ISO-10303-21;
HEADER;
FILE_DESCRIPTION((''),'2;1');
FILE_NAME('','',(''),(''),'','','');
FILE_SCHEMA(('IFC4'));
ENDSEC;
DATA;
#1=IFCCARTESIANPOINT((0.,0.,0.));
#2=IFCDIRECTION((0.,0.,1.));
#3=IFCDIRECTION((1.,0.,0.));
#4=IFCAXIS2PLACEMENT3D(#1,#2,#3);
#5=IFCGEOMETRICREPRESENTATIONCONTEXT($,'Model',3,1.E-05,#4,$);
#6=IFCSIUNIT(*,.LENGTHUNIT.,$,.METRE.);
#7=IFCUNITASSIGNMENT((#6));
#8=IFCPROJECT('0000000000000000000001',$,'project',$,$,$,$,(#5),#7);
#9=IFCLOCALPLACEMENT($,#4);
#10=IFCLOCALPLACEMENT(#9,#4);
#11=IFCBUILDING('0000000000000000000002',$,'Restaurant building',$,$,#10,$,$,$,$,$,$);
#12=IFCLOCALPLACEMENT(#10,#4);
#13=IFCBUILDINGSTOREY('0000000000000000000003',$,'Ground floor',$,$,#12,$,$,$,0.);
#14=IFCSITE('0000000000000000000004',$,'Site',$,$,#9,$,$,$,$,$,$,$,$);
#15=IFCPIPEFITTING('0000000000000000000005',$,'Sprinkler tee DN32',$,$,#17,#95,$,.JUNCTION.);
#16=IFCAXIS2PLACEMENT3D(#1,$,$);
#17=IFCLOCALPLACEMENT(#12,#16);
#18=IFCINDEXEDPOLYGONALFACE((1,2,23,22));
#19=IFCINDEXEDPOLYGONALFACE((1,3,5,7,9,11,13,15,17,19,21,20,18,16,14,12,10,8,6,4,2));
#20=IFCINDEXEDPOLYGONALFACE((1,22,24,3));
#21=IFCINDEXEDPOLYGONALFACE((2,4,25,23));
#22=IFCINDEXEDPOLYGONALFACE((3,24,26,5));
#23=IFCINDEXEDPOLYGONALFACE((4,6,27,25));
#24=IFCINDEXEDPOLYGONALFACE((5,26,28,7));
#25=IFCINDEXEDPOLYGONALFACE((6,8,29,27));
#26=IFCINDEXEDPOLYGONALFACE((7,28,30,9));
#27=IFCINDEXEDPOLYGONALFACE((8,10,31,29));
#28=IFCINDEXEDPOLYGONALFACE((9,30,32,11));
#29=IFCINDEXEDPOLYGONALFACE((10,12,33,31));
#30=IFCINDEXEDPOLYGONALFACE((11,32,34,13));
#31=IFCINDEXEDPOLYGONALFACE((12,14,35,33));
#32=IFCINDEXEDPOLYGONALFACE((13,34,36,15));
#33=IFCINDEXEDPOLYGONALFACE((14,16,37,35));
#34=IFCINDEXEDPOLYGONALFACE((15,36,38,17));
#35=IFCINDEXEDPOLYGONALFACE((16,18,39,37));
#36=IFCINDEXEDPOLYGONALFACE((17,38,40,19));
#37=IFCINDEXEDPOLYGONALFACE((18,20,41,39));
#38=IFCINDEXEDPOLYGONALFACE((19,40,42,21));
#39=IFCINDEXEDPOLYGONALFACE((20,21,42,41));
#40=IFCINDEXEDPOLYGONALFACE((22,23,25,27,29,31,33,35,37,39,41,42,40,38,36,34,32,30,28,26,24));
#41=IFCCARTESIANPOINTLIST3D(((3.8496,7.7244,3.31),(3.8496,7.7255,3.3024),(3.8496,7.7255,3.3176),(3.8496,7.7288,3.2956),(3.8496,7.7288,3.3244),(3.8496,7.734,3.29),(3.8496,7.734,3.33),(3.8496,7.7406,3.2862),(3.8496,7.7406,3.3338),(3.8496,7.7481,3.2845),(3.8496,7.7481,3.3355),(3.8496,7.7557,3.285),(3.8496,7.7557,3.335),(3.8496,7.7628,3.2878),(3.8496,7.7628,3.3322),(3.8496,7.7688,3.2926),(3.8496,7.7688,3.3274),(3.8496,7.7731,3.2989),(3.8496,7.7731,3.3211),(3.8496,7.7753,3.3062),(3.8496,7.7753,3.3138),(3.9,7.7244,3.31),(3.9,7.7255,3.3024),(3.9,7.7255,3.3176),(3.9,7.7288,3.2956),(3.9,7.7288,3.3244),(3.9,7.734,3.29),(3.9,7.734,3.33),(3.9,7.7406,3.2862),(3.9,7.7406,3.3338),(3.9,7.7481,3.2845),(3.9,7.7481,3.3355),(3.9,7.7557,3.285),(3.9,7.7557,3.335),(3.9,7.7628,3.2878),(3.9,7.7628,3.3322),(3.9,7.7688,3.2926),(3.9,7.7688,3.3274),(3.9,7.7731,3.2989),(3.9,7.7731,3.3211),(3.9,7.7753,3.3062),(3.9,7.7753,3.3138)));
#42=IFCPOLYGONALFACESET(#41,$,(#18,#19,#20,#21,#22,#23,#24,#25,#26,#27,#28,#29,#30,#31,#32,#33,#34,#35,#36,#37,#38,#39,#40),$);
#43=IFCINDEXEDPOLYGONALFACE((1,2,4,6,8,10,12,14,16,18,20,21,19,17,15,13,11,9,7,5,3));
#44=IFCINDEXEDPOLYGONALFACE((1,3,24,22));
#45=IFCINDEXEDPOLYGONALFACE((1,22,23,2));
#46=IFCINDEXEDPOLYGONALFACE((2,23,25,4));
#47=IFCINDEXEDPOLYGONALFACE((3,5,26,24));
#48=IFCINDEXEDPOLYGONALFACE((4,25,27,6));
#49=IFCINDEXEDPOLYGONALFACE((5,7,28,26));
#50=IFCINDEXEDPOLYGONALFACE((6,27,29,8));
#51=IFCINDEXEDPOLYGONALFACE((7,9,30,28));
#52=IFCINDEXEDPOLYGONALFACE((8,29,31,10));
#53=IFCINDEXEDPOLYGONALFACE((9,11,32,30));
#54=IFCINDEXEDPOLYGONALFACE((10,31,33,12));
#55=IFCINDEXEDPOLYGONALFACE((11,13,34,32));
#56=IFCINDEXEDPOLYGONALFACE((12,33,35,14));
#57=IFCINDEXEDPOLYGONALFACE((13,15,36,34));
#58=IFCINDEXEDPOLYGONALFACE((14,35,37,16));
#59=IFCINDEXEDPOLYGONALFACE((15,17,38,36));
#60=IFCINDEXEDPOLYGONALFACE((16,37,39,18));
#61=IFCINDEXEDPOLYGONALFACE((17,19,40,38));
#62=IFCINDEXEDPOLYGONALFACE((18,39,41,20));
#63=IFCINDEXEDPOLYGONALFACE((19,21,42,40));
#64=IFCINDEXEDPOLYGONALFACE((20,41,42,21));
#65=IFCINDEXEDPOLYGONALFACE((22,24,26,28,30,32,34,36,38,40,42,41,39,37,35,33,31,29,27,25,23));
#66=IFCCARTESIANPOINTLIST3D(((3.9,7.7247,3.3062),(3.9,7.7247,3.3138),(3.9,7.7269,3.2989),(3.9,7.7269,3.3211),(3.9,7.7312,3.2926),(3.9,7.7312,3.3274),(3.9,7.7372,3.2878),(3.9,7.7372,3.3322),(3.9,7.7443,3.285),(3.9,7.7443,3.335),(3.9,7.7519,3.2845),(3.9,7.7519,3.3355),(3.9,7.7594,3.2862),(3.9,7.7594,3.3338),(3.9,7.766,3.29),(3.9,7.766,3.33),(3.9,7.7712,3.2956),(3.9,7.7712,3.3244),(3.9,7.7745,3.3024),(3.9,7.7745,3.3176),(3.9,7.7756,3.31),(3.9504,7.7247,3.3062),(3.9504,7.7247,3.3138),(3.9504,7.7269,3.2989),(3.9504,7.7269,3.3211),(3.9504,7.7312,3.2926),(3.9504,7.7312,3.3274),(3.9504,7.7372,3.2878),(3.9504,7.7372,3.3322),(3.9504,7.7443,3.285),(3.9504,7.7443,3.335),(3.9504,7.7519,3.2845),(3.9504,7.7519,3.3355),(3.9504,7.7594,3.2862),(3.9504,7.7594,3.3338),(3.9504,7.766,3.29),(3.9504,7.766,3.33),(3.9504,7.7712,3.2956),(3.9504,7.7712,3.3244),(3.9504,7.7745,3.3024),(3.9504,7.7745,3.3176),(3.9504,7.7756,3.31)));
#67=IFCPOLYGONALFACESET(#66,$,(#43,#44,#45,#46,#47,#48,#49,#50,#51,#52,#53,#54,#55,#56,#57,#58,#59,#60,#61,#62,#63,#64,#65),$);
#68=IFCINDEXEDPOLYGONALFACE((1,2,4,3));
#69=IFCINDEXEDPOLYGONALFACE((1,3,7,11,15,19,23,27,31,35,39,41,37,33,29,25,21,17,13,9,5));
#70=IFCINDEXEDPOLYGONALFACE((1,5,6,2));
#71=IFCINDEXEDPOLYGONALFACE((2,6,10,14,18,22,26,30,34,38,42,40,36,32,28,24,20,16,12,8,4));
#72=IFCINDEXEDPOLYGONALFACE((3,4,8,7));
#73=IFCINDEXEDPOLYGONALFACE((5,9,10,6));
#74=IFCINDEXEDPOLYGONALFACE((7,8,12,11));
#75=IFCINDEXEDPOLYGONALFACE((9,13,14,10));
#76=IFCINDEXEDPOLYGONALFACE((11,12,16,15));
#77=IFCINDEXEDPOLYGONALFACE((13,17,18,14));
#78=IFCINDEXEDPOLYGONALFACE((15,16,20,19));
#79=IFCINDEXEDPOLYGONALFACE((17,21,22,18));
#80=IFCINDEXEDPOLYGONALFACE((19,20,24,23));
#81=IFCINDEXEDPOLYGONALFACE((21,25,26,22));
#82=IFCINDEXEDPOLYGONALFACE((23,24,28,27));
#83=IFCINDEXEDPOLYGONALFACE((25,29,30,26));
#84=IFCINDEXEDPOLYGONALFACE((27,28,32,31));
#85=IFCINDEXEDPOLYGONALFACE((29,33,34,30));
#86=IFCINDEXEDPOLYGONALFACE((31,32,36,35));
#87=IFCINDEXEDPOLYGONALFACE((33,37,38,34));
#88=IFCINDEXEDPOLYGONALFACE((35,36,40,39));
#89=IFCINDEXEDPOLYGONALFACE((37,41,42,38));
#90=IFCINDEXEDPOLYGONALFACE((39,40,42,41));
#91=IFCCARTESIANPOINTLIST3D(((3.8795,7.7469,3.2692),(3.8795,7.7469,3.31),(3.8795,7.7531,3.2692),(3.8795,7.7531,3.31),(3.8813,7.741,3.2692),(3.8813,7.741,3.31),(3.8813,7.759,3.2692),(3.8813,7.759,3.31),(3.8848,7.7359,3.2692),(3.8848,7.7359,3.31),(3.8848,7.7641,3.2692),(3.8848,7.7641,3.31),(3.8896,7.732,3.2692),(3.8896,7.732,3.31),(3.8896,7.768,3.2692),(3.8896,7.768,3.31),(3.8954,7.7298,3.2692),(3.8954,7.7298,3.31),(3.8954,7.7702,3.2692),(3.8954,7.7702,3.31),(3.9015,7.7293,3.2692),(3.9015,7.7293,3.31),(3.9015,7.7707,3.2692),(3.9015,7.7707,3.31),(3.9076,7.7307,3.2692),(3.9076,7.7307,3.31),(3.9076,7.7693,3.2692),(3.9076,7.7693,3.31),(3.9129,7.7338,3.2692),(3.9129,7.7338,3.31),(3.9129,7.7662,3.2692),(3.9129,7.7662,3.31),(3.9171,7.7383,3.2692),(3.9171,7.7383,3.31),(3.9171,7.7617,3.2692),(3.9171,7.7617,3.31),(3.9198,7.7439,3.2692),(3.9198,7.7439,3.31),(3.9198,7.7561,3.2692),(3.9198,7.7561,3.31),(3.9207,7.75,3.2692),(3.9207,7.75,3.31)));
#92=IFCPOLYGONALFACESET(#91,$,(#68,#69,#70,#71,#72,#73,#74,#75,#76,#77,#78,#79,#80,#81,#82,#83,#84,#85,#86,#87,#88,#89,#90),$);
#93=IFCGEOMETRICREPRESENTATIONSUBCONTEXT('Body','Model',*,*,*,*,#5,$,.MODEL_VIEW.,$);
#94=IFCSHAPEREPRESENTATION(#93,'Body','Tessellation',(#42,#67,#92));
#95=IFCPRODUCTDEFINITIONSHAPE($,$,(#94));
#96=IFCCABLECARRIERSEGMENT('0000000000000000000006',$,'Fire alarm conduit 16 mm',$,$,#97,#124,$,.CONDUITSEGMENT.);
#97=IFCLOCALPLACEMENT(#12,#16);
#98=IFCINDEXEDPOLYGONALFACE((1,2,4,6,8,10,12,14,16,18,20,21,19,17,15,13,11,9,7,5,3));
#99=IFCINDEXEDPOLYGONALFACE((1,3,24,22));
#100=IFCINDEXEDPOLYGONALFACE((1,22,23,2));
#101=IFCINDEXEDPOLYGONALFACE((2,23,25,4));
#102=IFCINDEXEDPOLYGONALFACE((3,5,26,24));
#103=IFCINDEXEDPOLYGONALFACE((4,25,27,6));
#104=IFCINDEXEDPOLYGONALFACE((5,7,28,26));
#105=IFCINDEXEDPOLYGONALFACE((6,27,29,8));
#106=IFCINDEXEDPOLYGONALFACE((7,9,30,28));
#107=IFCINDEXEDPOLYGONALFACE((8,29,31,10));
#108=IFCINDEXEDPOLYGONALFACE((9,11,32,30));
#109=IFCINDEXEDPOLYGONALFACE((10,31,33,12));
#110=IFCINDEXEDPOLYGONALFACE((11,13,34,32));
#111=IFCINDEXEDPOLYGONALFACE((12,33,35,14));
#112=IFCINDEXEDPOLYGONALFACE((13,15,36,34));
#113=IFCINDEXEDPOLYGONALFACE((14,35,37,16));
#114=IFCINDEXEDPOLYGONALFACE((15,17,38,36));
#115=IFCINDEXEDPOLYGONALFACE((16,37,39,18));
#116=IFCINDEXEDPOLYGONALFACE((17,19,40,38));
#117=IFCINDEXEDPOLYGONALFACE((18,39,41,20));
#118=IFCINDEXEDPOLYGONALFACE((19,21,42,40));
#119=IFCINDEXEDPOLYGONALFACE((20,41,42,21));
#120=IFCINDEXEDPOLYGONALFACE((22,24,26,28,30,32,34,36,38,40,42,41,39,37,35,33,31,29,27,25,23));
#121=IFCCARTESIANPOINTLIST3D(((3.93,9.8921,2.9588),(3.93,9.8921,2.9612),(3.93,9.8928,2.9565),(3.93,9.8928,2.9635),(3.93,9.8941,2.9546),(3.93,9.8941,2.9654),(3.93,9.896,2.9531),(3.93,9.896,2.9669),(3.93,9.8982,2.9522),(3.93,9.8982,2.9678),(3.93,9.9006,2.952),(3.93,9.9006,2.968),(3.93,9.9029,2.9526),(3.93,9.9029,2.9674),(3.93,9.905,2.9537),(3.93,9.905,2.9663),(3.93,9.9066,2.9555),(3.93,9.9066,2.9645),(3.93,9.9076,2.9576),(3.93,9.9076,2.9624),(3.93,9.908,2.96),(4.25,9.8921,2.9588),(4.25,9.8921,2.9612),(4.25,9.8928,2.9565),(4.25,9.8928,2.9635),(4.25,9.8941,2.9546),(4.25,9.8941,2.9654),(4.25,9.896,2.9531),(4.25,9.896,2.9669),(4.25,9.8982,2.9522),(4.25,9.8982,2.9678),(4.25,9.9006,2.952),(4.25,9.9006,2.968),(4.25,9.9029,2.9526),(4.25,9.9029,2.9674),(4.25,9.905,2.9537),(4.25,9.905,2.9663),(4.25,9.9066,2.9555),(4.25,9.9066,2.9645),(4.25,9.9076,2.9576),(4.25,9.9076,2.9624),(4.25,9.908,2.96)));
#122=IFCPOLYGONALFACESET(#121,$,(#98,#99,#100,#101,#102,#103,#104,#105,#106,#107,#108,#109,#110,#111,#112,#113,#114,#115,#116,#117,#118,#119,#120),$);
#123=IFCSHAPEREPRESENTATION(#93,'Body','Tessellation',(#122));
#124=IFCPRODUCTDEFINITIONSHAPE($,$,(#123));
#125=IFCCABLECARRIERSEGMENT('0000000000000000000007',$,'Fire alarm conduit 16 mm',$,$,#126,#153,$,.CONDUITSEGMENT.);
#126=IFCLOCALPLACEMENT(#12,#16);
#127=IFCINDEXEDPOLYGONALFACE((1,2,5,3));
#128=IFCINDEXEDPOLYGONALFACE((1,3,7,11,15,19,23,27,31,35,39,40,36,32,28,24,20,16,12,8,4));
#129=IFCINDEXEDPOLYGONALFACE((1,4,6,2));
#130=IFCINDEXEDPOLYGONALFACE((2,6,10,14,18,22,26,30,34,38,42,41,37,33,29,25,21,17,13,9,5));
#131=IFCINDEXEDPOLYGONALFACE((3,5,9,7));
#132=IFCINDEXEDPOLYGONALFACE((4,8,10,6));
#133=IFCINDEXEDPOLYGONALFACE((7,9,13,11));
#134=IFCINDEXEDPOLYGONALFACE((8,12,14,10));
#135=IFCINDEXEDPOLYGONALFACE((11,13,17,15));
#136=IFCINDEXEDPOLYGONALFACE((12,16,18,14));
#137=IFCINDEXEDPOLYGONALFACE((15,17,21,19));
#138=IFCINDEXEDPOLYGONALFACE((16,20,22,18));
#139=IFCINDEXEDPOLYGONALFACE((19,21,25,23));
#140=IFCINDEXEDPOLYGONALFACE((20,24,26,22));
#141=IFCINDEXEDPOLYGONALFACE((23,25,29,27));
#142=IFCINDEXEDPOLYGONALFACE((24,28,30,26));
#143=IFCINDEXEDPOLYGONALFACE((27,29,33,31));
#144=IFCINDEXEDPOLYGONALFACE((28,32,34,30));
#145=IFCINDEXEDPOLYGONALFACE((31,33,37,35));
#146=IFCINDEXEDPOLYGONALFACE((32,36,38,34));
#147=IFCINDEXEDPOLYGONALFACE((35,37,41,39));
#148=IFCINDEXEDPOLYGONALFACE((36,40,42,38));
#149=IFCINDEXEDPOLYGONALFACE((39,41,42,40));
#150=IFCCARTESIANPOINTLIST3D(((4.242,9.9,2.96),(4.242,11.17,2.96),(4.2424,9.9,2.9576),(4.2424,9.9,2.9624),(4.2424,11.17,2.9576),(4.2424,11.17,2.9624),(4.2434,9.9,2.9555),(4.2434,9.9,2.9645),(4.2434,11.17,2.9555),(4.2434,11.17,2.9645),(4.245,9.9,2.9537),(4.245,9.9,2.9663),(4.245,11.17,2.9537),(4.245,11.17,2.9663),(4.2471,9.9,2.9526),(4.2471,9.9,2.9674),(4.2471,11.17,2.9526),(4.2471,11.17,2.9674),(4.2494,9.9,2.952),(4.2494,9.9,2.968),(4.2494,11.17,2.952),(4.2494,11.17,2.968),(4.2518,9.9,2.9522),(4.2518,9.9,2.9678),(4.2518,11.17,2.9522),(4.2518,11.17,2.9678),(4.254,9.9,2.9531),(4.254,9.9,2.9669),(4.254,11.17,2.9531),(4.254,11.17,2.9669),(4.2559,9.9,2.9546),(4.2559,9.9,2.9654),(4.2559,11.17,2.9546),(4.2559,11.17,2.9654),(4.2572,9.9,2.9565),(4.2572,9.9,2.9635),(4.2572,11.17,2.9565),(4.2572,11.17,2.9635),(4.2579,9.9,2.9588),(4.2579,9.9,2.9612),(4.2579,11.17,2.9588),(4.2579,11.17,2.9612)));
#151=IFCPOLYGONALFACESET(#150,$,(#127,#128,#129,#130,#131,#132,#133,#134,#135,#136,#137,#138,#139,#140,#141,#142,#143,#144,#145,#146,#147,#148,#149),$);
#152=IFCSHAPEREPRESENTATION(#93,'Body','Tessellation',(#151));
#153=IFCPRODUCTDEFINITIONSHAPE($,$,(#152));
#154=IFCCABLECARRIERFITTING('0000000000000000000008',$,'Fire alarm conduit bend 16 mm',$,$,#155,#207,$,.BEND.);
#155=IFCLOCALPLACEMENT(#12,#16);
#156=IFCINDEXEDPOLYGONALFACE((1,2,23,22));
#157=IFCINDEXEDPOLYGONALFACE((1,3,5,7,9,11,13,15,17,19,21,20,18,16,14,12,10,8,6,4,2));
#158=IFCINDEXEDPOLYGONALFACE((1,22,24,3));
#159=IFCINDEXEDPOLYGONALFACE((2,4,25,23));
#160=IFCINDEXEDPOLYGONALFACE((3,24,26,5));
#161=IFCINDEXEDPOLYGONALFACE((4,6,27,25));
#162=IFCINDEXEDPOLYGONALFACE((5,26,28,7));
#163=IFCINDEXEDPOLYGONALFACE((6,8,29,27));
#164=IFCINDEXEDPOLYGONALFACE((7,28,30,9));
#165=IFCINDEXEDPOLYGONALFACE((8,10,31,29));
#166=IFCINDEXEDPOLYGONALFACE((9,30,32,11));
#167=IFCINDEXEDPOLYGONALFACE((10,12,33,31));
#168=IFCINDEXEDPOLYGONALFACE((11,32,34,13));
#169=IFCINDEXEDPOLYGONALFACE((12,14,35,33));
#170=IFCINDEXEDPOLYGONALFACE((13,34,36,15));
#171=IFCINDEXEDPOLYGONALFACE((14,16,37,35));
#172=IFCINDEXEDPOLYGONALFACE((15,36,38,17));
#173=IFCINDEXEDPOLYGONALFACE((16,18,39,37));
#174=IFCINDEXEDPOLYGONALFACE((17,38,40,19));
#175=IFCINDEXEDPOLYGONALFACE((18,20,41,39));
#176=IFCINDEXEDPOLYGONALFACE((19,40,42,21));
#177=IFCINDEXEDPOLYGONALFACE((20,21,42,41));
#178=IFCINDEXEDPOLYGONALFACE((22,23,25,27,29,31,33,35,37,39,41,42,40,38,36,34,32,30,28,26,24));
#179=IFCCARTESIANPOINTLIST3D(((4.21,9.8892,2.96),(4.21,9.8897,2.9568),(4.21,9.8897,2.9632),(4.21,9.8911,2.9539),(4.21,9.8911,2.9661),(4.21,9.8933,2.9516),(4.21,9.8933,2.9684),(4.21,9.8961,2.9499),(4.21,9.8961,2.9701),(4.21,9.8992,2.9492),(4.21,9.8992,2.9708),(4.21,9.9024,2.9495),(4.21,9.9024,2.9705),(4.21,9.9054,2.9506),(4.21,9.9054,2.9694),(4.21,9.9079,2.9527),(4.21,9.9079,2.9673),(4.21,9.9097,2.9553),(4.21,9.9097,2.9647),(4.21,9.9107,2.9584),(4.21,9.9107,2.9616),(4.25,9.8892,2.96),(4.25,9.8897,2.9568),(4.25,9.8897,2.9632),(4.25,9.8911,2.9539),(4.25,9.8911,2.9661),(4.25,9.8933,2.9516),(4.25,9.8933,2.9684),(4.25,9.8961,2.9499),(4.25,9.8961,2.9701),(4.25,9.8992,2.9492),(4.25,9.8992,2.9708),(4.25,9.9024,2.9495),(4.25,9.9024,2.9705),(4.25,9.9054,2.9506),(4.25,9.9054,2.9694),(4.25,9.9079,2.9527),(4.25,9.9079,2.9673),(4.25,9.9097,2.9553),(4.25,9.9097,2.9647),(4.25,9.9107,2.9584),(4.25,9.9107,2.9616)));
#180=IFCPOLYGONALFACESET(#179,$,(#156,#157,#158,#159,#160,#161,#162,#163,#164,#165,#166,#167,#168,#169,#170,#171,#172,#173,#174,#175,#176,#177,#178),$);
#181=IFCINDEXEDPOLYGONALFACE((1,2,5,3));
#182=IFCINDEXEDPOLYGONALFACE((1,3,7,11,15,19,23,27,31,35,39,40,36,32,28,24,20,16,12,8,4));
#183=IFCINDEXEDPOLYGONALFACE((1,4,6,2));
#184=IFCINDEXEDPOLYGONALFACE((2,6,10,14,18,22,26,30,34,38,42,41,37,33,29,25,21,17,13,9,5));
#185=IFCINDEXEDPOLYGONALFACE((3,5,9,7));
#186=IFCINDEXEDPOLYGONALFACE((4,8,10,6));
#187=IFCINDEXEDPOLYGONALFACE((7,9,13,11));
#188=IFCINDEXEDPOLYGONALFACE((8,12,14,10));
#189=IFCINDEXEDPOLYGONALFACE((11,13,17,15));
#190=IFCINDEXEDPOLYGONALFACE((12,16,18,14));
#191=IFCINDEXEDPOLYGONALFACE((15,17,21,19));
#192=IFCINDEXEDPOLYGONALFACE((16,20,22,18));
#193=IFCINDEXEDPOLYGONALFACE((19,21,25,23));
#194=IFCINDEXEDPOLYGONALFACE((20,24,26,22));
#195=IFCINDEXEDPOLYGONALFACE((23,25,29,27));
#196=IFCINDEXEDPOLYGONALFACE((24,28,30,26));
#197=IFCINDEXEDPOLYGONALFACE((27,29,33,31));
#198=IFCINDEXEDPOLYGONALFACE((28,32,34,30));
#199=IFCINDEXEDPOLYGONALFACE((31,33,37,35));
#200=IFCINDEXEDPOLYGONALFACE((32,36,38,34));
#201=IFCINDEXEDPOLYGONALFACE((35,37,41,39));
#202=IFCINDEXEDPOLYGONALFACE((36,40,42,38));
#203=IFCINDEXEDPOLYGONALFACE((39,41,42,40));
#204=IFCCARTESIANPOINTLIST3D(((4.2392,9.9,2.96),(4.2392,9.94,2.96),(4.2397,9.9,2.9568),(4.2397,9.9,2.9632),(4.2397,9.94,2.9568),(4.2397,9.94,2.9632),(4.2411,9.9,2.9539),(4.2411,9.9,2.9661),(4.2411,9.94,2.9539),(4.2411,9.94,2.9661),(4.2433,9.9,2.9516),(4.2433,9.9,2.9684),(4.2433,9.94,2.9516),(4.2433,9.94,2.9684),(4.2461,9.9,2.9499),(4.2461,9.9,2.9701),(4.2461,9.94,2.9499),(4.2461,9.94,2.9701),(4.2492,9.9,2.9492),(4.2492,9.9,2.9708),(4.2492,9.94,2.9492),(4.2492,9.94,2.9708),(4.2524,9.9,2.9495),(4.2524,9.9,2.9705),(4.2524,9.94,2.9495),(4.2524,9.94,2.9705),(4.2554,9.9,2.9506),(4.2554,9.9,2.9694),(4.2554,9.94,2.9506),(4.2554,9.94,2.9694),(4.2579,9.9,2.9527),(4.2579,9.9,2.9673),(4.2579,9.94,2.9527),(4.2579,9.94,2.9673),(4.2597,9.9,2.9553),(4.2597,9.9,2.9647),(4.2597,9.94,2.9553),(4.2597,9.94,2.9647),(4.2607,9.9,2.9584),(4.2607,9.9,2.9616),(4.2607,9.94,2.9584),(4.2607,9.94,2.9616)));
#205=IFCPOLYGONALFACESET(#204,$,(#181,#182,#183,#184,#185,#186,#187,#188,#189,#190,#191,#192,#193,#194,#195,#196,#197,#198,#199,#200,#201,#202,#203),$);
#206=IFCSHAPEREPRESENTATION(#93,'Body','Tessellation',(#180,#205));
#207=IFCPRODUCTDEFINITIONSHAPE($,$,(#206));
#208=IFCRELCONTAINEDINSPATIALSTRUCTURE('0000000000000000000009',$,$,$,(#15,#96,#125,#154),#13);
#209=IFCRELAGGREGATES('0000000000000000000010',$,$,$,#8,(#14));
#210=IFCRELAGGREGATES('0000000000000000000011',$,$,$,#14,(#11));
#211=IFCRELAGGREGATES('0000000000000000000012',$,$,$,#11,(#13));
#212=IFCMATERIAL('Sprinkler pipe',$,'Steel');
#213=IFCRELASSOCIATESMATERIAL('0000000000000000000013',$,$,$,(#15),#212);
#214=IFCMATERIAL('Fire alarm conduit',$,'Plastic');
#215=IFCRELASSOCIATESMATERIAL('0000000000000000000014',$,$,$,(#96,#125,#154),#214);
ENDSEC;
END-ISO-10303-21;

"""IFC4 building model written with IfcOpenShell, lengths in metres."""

from ifc_helpers import new_model, si_unit, frame, origin_with_axes, origin_2d, place, context, subcontext, project, spatial, circle, extrude, material, element, save


model = new_model("IFC4")

# Units and contexts
model_context = context("Model", 3, precision=1e-05, world=origin_with_axes())
body_context = subcontext(model_context, "Body", "Model", "MODEL_VIEW")
ifc_project = project(units=[si_unit("LENGTHUNIT", "METRE")], contexts=[model_context])

# Site, building, storey
site_placement = place(None, origin_with_axes())
site = spatial("IfcSite", under=ifc_project, at=site_placement, Name="Site")
building_placement = place(site_placement, origin_with_axes())
building = spatial("IfcBuilding", under=site, at=building_placement, Name="Restaurant building")
storey_placement = place(building_placement, origin_with_axes())
storey = spatial("IfcBuildingStorey", under=building, at=storey_placement, Name="Ground floor", Elevation=0.0)

# Shared definitions
ifc_material_1 = material(Name="Sprinkler pipe", Category="Steel")

# Pipe fitting
pipe_fitting_1_placement = place(storey_placement, frame((3.9, 7.75, 3.31)))
element("IfcPipeFitting", 1, at=pipe_fitting_1_placement, inside=storey, material=ifc_material_1, Name="Sprinkler tee DN32", PredefinedType="JUNCTION", context=body_context, shape_type="SweptSolid", body=[
    extrude(circle(Radius=0.0256, at=origin_2d()), frame((0.0, 0.0, 0.0), z_axis=(-1.0, 0.0, 0.0), x_axis=(0.0, -1.0, 0.0)), (0.0, 0.0, 1.0), 0.0504),
    extrude(circle(Radius=0.0256, at=origin_2d()), frame((0.0, 0.0, 0.0), z_axis=(1.0, 0.0, 0.0), x_axis=(0.0, 1.0, 0.0)), (0.0, 0.0, 1.0), 0.0504),
    extrude(circle(Radius=0.0207, at=origin_2d()), frame((0.0, 0.0, 0.0), z_axis=(0.0, 0.0, -1.0), x_axis=(1.0, 0.0, 0.0)), (0.0, 0.0, 1.0), 0.0408),
])

# Cable carrier segments
ifc_material_2 = material(Name="Fire alarm conduit", Category="Plastic")
cable_carrier_segment_1_placement = place(storey_placement, frame((3.93, 9.9, 2.96)))
element("IfcCableCarrierSegment", 2, at=cable_carrier_segment_1_placement, inside=storey, material=ifc_material_2, Name="Fire alarm conduit 16 mm", PredefinedType="CONDUITSEGMENT", context=body_context, shape_type="SweptSolid", body=[
    extrude(circle(Radius=0.008, at=origin_2d()), frame((0.0, 0.0, 0.0), z_axis=(1.0, 0.0, 0.0), x_axis=(0.0, 1.0, 0.0)), (0.0, 0.0, 1.0), 0.32),
])
cable_carrier_segment_2_placement = place(storey_placement, frame((4.25, 9.9, 2.96)))
element("IfcCableCarrierSegment", 3, at=cable_carrier_segment_2_placement, inside=storey, material=ifc_material_2, Name="Fire alarm conduit 16 mm", PredefinedType="CONDUITSEGMENT", context=body_context, shape_type="SweptSolid", body=[
    extrude(circle(Radius=0.008, at=origin_2d()), frame((0.0, 0.0, 0.0), z_axis=(0.0, 1.0, 0.0), x_axis=(-1.0, 0.0, 0.0)), (0.0, 0.0, 1.0), 1.27),
])

# Cable carrier fitting
cable_carrier_fitting_1_placement = place(storey_placement, frame((4.25, 9.9, 2.96)))
element("IfcCableCarrierFitting", 4, at=cable_carrier_fitting_1_placement, inside=storey, material=ifc_material_2, Name="Fire alarm conduit bend 16 mm", PredefinedType="BEND", context=body_context, shape_type="SweptSolid", body=[
    extrude(circle(Radius=0.0108, at=origin_2d()), frame((0.0, 0.0, 0.0), z_axis=(-1.0, 0.0, 0.0), x_axis=(0.0, -1.0, 0.0)), (0.0, 0.0, 1.0), 0.04),
    extrude(circle(Radius=0.0108, at=origin_2d()), frame((0.0, 0.0, 0.0), z_axis=(0.0, 1.0, 0.0), x_axis=(-1.0, 0.0, 0.0)), (0.0, 0.0, 1.0), 0.04),
])

save(model, "model.ifc")
